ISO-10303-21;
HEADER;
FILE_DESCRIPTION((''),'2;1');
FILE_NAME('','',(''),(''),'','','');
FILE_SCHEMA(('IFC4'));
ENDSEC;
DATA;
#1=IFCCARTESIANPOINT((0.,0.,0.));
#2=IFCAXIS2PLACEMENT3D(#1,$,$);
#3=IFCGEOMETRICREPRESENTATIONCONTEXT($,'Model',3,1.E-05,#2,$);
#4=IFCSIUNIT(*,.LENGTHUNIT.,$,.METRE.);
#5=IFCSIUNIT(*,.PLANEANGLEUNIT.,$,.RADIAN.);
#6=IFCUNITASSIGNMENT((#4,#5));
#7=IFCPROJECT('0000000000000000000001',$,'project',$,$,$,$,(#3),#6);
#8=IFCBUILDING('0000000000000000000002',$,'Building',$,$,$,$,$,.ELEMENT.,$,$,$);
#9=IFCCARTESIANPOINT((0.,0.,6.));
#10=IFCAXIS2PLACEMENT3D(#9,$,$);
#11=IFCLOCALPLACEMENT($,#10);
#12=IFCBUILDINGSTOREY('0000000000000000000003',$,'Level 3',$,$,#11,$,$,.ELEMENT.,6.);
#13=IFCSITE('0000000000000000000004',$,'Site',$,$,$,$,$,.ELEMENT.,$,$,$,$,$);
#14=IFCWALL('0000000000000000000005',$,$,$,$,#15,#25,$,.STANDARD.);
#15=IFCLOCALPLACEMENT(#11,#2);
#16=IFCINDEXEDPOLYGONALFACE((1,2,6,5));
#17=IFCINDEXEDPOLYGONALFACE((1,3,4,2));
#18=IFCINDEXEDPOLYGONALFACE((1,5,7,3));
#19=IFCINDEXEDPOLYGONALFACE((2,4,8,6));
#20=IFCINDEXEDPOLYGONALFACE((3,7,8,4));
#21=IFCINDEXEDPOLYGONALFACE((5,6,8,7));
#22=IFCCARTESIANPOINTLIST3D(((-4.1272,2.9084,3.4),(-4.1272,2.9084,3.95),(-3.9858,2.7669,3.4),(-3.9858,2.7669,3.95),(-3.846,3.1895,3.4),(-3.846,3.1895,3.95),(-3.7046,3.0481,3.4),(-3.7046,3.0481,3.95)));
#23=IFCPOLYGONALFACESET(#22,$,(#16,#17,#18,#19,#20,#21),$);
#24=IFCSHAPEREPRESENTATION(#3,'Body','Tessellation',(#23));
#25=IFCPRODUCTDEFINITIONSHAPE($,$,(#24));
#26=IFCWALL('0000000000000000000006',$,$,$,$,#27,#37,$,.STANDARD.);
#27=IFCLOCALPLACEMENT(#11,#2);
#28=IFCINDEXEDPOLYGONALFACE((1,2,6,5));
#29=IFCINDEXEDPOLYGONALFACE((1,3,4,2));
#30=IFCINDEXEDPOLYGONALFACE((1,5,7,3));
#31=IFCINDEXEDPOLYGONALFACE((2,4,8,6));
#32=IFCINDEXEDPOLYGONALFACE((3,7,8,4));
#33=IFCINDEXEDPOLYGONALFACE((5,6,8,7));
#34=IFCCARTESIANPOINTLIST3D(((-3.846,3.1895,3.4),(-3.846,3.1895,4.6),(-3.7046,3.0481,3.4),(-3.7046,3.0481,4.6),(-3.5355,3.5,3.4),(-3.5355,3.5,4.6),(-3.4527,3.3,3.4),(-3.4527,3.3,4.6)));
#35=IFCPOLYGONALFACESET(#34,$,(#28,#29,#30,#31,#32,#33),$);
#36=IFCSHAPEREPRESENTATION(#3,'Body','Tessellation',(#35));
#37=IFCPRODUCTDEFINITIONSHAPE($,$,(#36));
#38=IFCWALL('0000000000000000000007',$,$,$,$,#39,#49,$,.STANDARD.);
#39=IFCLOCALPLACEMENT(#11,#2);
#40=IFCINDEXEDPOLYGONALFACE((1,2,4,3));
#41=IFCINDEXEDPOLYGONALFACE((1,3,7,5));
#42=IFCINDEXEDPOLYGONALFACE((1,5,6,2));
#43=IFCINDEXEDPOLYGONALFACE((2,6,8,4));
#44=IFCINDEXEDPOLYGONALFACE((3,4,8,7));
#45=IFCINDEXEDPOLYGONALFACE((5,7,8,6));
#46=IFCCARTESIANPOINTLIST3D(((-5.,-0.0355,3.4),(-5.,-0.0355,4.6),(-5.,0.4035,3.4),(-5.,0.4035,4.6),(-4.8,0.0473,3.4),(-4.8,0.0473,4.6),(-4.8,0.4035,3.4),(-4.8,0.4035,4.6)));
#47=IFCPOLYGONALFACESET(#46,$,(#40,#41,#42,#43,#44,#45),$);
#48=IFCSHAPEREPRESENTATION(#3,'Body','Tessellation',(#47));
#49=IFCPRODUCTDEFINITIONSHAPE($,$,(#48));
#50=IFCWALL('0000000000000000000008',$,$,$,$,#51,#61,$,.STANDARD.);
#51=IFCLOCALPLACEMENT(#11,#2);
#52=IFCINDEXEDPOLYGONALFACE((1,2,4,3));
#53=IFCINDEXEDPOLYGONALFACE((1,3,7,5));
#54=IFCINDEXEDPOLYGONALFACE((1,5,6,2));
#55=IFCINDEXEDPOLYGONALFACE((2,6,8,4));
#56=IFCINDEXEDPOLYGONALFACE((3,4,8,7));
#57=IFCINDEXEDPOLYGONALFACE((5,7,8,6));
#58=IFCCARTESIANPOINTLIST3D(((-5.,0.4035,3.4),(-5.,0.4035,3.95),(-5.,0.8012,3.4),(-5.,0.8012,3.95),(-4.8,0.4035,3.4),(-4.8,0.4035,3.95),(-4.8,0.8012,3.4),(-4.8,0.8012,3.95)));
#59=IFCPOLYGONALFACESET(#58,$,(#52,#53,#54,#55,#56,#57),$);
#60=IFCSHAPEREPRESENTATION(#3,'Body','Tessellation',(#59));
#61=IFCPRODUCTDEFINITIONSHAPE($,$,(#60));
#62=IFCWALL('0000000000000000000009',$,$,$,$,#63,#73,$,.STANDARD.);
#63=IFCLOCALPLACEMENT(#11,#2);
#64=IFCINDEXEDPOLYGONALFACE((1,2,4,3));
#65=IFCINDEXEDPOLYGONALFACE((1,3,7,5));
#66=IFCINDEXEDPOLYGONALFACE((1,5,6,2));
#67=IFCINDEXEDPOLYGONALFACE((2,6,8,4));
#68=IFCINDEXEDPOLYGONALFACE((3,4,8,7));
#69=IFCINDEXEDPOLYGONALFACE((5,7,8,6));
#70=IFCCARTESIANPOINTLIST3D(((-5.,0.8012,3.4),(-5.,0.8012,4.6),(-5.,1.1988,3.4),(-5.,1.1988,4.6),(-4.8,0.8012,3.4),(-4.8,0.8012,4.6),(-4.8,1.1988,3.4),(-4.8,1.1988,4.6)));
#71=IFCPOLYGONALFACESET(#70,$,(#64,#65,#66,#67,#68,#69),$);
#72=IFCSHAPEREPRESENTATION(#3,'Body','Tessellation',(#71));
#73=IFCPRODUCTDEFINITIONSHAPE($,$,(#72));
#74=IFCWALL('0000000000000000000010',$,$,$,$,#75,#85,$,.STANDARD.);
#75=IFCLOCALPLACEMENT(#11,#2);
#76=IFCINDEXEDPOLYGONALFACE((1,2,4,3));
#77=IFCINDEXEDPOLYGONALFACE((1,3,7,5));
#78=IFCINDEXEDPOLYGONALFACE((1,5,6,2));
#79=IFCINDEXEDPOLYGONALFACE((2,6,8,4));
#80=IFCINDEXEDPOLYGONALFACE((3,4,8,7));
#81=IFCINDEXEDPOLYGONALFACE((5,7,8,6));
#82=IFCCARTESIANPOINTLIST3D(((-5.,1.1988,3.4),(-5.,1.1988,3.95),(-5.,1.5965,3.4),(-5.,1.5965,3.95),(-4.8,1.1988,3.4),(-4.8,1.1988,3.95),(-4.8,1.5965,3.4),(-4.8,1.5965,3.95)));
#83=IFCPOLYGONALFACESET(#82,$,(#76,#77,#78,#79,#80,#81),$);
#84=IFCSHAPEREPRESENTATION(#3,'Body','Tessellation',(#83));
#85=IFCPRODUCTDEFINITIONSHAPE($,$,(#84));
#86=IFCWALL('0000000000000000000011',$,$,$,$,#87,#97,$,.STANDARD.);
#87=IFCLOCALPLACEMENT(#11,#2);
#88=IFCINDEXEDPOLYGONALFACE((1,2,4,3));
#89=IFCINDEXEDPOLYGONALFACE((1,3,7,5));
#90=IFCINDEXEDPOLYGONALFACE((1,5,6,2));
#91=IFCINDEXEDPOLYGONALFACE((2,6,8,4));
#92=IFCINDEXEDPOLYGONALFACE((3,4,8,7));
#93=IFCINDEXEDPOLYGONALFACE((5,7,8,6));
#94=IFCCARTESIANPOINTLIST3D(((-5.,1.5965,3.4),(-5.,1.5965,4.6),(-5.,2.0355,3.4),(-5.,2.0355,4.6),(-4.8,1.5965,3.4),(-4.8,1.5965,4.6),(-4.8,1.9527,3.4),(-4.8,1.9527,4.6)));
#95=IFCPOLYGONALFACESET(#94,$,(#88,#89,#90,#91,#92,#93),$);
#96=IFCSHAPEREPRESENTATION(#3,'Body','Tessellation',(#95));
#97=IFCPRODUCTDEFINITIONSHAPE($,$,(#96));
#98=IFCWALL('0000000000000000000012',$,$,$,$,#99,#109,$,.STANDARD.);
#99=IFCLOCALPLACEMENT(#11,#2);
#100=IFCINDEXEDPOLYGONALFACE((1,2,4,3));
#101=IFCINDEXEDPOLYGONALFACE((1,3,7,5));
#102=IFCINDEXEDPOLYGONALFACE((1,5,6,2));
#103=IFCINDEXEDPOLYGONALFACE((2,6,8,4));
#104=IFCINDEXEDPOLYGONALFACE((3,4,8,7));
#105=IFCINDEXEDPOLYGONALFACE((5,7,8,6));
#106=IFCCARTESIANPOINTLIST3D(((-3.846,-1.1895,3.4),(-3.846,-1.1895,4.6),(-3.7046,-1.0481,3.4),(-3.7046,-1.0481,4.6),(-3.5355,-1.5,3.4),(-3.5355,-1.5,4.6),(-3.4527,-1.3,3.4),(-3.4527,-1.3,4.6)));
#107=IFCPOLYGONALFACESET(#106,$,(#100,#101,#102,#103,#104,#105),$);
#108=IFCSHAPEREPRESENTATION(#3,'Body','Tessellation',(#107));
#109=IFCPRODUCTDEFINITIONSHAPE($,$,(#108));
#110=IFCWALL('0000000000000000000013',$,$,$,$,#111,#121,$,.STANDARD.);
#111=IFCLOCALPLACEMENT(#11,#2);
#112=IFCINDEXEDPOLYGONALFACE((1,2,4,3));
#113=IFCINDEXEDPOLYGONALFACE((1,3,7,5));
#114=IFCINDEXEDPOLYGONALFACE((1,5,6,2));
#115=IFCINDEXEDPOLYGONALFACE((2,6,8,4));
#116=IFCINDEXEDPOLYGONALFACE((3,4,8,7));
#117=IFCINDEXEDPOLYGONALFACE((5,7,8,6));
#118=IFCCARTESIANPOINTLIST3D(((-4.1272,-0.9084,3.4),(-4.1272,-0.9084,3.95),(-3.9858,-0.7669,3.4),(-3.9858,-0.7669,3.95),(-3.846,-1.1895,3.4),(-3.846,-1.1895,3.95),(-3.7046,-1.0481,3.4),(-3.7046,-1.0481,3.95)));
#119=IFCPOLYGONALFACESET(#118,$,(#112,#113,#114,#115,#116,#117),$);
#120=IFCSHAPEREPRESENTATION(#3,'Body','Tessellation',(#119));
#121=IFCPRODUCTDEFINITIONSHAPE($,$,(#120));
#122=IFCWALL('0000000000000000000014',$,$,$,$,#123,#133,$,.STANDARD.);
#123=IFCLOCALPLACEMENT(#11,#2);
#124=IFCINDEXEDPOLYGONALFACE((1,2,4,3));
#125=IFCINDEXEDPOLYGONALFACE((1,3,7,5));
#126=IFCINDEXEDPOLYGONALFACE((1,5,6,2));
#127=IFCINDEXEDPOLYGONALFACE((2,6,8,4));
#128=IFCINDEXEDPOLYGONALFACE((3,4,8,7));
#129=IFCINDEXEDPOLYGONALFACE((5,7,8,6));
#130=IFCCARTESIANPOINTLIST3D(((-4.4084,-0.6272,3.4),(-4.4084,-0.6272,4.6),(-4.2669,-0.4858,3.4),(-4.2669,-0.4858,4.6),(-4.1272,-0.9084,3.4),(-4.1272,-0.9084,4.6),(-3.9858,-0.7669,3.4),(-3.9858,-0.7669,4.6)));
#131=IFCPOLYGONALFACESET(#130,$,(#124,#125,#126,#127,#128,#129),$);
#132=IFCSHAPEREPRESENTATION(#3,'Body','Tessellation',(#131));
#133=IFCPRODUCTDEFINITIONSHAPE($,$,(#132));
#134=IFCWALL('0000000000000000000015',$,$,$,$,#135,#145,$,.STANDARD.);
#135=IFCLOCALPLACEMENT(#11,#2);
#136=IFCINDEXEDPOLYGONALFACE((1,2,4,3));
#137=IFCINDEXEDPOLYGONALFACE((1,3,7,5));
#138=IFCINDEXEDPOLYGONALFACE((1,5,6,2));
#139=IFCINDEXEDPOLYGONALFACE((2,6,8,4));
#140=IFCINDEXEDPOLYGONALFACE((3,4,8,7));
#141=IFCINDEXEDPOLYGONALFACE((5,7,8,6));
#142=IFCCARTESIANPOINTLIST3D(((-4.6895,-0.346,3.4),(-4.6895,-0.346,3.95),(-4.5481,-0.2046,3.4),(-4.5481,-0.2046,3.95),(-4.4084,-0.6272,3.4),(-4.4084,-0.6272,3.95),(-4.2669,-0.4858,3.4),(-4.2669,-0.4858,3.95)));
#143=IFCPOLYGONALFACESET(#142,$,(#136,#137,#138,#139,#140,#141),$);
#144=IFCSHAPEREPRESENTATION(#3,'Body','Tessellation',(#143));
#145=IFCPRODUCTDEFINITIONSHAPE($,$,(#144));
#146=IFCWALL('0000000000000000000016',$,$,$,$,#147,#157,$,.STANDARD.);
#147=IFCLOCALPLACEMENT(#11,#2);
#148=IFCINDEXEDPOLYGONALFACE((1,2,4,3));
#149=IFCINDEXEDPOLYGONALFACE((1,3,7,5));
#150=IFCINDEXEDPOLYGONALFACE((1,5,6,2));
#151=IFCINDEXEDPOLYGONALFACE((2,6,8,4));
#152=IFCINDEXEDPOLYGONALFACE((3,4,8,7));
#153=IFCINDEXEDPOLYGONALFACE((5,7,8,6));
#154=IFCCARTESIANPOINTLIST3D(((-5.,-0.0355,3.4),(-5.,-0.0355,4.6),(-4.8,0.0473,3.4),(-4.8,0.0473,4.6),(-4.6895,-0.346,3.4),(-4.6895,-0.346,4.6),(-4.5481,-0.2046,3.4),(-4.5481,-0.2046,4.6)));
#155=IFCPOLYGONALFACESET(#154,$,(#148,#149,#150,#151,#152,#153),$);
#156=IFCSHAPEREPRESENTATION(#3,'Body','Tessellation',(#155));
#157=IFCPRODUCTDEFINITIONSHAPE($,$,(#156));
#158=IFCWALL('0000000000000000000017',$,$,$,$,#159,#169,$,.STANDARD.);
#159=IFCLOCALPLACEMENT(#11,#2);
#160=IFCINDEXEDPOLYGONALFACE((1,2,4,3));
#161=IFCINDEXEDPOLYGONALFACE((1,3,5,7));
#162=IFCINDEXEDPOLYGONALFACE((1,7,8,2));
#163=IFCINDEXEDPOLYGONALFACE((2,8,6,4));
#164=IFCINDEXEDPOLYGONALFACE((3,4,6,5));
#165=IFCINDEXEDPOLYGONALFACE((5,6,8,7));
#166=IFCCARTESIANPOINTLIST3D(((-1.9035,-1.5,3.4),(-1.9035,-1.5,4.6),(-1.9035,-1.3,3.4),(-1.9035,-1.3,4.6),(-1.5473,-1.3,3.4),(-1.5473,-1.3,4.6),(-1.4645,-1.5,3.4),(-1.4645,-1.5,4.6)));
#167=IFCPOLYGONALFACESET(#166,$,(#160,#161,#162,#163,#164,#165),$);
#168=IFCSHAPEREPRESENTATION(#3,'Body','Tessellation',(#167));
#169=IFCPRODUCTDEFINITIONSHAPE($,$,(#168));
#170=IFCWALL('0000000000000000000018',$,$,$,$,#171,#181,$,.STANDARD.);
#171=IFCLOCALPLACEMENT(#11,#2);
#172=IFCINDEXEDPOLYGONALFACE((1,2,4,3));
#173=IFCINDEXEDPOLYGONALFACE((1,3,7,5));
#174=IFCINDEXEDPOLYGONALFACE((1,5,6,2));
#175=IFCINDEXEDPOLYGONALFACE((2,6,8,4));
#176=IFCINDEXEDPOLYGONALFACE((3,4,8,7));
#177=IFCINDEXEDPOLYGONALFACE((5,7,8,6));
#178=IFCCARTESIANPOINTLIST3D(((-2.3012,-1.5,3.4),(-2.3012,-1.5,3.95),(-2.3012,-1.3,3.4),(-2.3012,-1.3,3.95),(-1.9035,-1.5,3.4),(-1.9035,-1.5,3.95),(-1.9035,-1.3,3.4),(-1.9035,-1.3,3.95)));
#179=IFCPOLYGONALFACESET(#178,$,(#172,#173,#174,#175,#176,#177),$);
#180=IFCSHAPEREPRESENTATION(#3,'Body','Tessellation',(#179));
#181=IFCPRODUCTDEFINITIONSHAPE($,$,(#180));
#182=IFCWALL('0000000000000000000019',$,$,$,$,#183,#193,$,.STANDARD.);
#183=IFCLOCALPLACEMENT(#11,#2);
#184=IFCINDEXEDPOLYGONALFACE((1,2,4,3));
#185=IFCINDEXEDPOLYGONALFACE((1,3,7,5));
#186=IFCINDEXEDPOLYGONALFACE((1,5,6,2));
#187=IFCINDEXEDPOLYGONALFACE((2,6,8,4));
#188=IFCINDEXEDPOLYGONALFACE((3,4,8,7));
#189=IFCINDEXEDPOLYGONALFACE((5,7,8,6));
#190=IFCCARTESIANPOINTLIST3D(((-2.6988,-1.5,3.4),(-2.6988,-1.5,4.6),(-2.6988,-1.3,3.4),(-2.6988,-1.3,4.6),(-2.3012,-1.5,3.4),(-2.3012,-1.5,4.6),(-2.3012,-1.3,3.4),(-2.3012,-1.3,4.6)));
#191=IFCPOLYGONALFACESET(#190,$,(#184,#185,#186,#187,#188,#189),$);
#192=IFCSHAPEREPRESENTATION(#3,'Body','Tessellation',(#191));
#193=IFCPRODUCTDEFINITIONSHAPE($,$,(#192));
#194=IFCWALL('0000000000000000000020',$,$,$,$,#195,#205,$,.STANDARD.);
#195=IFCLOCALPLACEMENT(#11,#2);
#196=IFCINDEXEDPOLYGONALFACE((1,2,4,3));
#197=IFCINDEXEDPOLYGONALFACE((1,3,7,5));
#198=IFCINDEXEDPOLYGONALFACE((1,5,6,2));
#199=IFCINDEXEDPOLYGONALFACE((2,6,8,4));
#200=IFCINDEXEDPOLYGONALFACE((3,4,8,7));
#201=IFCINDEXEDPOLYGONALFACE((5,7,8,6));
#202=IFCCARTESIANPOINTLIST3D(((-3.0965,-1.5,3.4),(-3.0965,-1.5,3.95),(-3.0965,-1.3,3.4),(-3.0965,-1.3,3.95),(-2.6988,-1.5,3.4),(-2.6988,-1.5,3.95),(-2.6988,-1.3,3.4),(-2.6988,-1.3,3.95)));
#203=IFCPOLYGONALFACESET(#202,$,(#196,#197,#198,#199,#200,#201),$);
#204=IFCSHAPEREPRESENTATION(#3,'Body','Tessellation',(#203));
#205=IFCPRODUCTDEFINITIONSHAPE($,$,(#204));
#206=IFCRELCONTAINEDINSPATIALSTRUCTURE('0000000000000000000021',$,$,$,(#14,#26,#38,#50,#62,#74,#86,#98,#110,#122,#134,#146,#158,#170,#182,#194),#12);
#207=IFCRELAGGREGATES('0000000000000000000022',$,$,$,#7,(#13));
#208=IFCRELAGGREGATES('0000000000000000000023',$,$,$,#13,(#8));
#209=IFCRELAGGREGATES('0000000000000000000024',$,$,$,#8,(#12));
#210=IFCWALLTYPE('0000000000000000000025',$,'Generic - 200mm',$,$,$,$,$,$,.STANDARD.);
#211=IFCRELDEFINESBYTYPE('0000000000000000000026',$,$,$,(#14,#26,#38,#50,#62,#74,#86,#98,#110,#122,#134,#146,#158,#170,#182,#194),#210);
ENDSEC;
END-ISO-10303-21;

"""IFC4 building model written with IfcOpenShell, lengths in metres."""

from ifc_helpers import new_model, si_unit, frame, frame_2d, origin, place, context, project, spatial, polyline, rectangle, outline, extrude, type_object, element, save


model = new_model("IFC4")

# Units and contexts
model_context = context("Model", 3, precision=1e-05, world=origin())
ifc_project = project(units=[si_unit("LENGTHUNIT", "METRE"), si_unit("PLANEANGLEUNIT", "RADIAN")], contexts=[model_context])

# Site, building, storey
site = spatial("IfcSite", under=ifc_project, Name="Site", CompositionType="ELEMENT")
building = spatial("IfcBuilding", under=site, Name="Building", CompositionType="ELEMENT")
storey_placement = place(None, frame((0.0, 0.0, 6.0)))
storey = spatial("IfcBuildingStorey", under=building, at=storey_placement, Name="Level 3", CompositionType="ELEMENT", Elevation=6.0)

# Walls
wall_type = type_object("IfcWallType", Name="Generic - 200mm", PredefinedType="STANDARD")
wall_1_placement = place(None, frame((-4.0565, 2.8376, 9.4), z_axis=(0.0, 0.0, 1.0), x_axis=(0.707107, 0.707107, 0.0)))
element("IfcWall", 1, at=wall_1_placement, inside=storey, type_object=wall_type, PredefinedType="STANDARD", context=model_context, shape_type="SweptSolid", body=[
    extrude(rectangle(XDim=0.3976, YDim=0.2, at=frame_2d((0.1988, 0.0))), origin(), (0.0, 0.0, 1.0), 0.55),
])
wall_2_placement = place(None, frame((-3.7753, 3.1188, 9.4), z_axis=(0.0, 0.0, 1.0), x_axis=(0.707107, 0.707107, 0.0)))
element("IfcWall", 2, at=wall_2_placement, inside=storey, type_object=wall_type, PredefinedType="STANDARD", context=model_context, shape_type="SweptSolid", body=[
    extrude(outline(polyline([(0.0, -0.1), (0.3562, -0.1), (0.4391, 0.1), (0.0, 0.1), (0.0, -0.1)])), origin(), (0.0, 0.0, 1.0), 1.2),
])
wall_3_placement = place(None, frame((-4.9, 0.0059, 9.4), z_axis=(0.0, 0.0, 1.0), x_axis=(0.0, 1.0, 0.0)))
element("IfcWall", 3, at=wall_3_placement, inside=storey, type_object=wall_type, PredefinedType="STANDARD", context=model_context, shape_type="SweptSolid", body=[
    extrude(outline(polyline([(0.0414, -0.1), (0.3976, -0.1), (0.3976, 0.1), (-0.0414, 0.1), (0.0414, -0.1)])), origin(), (0.0, 0.0, 1.0), 1.2),
])
wall_4_placement = place(None, frame((-4.9, 0.4035, 9.4), z_axis=(0.0, 0.0, 1.0), x_axis=(0.0, 1.0, 0.0)))
element("IfcWall", 4, at=wall_4_placement, inside=storey, type_object=wall_type, PredefinedType="STANDARD", context=model_context, shape_type="SweptSolid", body=[
    extrude(rectangle(XDim=0.3976, YDim=0.2, at=frame_2d((0.1988, 0.0))), origin(), (0.0, 0.0, 1.0), 0.55),
])
wall_5_placement = place(None, frame((-4.9, 0.8012, 9.4), z_axis=(0.0, 0.0, 1.0), x_axis=(0.0, 1.0, 0.0)))
element("IfcWall", 5, at=wall_5_placement, inside=storey, type_object=wall_type, PredefinedType="STANDARD", context=model_context, shape_type="SweptSolid", body=[
    extrude(rectangle(XDim=0.3976, YDim=0.2, at=frame_2d((0.1988, 0.0))), origin(), (0.0, 0.0, 1.0), 1.2),
])
wall_6_placement = place(None, frame((-4.9, 1.1988, 9.4), z_axis=(0.0, 0.0, 1.0), x_axis=(0.0, 1.0, 0.0)))
element("IfcWall", 6, at=wall_6_placement, inside=storey, type_object=wall_type, PredefinedType="STANDARD", context=model_context, shape_type="SweptSolid", body=[
    extrude(rectangle(XDim=0.3976, YDim=0.2, at=frame_2d((0.1988, 0.0))), origin(), (0.0, 0.0, 1.0), 0.55),
])
wall_7_placement = place(None, frame((-4.9, 1.5965, 9.4), z_axis=(0.0, 0.0, 1.0), x_axis=(0.0, 1.0, 0.0)))
element("IfcWall", 7, at=wall_7_placement, inside=storey, type_object=wall_type, PredefinedType="STANDARD", context=model_context, shape_type="SweptSolid", body=[
    extrude(outline(polyline([(0.0, -0.1), (0.3562, -0.1), (0.4391, 0.1), (0.0, 0.1), (0.0, -0.1)])), origin(), (0.0, 0.0, 1.0), 1.2),
])
wall_8_placement = place(None, frame((-3.4941, -1.4, 9.4), z_axis=(0.0, 0.0, 1.0), x_axis=(-0.707107, 0.707107, 0.0)))
element("IfcWall", 8, at=wall_8_placement, inside=storey, type_object=wall_type, PredefinedType="STANDARD", context=model_context, shape_type="SweptSolid", body=[
    extrude(outline(polyline([(0.0414, -0.1), (0.3976, -0.1), (0.3976, 0.1), (-0.0414, 0.1), (0.0414, -0.1)])), origin(), (0.0, 0.0, 1.0), 1.2),
])
wall_9_placement = place(None, frame((-3.7753, -1.1188, 9.4), z_axis=(0.0, 0.0, 1.0), x_axis=(-0.707107, 0.707107, 0.0)))
element("IfcWall", 9, at=wall_9_placement, inside=storey, type_object=wall_type, PredefinedType="STANDARD", context=model_context, shape_type="SweptSolid", body=[
    extrude(rectangle(XDim=0.3976, YDim=0.2, at=frame_2d((0.1988, 0.0))), origin(), (0.0, 0.0, 1.0), 0.55),
])
wall_10_placement = place(None, frame((-4.0565, -0.8376, 9.4), z_axis=(0.0, 0.0, 1.0), x_axis=(-0.707107, 0.707107, 0.0)))
element("IfcWall", 10, at=wall_10_placement, inside=storey, type_object=wall_type, PredefinedType="STANDARD", context=model_context, shape_type="SweptSolid", body=[
    extrude(rectangle(XDim=0.3976, YDim=0.2, at=frame_2d((0.1988, 0.0))), origin(), (0.0, 0.0, 1.0), 1.2),
])
wall_11_placement = place(None, frame((-4.3376, -0.5565, 9.4), z_axis=(0.0, 0.0, 1.0), x_axis=(-0.707107, 0.707107, 0.0)))
element("IfcWall", 11, at=wall_11_placement, inside=storey, type_object=wall_type, PredefinedType="STANDARD", context=model_context, shape_type="SweptSolid", body=[
    extrude(rectangle(XDim=0.3976, YDim=0.2, at=frame_2d((0.1988, 0.0))), origin(), (0.0, 0.0, 1.0), 0.55),
])
wall_12_placement = place(None, frame((-4.6188, -0.2753, 9.4), z_axis=(0.0, 0.0, 1.0), x_axis=(-0.707107, 0.707107, 0.0)))
element("IfcWall", 12, at=wall_12_placement, inside=storey, type_object=wall_type, PredefinedType="STANDARD", context=model_context, shape_type="SweptSolid", body=[
    extrude(outline(polyline([(0.0, -0.1), (0.3562, -0.1), (0.4391, 0.1), (0.0, 0.1), (0.0, -0.1)])), origin(), (0.0, 0.0, 1.0), 1.2),
])
wall_13_placement = place(None, frame((-1.5059, -1.4, 9.4), z_axis=(0.0, 0.0, 1.0), x_axis=(-1.0, 0.0, 0.0)))
element("IfcWall", 13, at=wall_13_placement, inside=storey, type_object=wall_type, PredefinedType="STANDARD", context=model_context, shape_type="SweptSolid", body=[
    extrude(outline(polyline([(0.0414, -0.1), (0.3976, -0.1), (0.3976, 0.1), (-0.0414, 0.1), (0.0414, -0.1)])), origin(), (0.0, 0.0, 1.0), 1.2),
])
wall_14_placement = place(None, frame((-1.9035, -1.4, 9.4), z_axis=(0.0, 0.0, 1.0), x_axis=(-1.0, 0.0, 0.0)))
element("IfcWall", 14, at=wall_14_placement, inside=storey, type_object=wall_type, PredefinedType="STANDARD", context=model_context, shape_type="SweptSolid", body=[
    extrude(rectangle(XDim=0.3976, YDim=0.2, at=frame_2d((0.1988, 0.0))), origin(), (0.0, 0.0, 1.0), 0.55),
])
wall_15_placement = place(None, frame((-2.3012, -1.4, 9.4), z_axis=(0.0, 0.0, 1.0), x_axis=(-1.0, 0.0, 0.0)))
element("IfcWall", 15, at=wall_15_placement, inside=storey, type_object=wall_type, PredefinedType="STANDARD", context=model_context, shape_type="SweptSolid", body=[
    extrude(rectangle(XDim=0.3976, YDim=0.2, at=frame_2d((0.1988, 0.0))), origin(), (0.0, 0.0, 1.0), 1.2),
])
wall_16_placement = place(None, frame((-2.6988, -1.4, 9.4), z_axis=(0.0, 0.0, 1.0), x_axis=(-1.0, 0.0, 0.0)))
element("IfcWall", 16, at=wall_16_placement, inside=storey, type_object=wall_type, PredefinedType="STANDARD", context=model_context, shape_type="SweptSolid", body=[
    extrude(rectangle(XDim=0.3976, YDim=0.2, at=frame_2d((0.1988, 0.0))), origin(), (0.0, 0.0, 1.0), 0.55),
])

save(model, "model.ifc")
